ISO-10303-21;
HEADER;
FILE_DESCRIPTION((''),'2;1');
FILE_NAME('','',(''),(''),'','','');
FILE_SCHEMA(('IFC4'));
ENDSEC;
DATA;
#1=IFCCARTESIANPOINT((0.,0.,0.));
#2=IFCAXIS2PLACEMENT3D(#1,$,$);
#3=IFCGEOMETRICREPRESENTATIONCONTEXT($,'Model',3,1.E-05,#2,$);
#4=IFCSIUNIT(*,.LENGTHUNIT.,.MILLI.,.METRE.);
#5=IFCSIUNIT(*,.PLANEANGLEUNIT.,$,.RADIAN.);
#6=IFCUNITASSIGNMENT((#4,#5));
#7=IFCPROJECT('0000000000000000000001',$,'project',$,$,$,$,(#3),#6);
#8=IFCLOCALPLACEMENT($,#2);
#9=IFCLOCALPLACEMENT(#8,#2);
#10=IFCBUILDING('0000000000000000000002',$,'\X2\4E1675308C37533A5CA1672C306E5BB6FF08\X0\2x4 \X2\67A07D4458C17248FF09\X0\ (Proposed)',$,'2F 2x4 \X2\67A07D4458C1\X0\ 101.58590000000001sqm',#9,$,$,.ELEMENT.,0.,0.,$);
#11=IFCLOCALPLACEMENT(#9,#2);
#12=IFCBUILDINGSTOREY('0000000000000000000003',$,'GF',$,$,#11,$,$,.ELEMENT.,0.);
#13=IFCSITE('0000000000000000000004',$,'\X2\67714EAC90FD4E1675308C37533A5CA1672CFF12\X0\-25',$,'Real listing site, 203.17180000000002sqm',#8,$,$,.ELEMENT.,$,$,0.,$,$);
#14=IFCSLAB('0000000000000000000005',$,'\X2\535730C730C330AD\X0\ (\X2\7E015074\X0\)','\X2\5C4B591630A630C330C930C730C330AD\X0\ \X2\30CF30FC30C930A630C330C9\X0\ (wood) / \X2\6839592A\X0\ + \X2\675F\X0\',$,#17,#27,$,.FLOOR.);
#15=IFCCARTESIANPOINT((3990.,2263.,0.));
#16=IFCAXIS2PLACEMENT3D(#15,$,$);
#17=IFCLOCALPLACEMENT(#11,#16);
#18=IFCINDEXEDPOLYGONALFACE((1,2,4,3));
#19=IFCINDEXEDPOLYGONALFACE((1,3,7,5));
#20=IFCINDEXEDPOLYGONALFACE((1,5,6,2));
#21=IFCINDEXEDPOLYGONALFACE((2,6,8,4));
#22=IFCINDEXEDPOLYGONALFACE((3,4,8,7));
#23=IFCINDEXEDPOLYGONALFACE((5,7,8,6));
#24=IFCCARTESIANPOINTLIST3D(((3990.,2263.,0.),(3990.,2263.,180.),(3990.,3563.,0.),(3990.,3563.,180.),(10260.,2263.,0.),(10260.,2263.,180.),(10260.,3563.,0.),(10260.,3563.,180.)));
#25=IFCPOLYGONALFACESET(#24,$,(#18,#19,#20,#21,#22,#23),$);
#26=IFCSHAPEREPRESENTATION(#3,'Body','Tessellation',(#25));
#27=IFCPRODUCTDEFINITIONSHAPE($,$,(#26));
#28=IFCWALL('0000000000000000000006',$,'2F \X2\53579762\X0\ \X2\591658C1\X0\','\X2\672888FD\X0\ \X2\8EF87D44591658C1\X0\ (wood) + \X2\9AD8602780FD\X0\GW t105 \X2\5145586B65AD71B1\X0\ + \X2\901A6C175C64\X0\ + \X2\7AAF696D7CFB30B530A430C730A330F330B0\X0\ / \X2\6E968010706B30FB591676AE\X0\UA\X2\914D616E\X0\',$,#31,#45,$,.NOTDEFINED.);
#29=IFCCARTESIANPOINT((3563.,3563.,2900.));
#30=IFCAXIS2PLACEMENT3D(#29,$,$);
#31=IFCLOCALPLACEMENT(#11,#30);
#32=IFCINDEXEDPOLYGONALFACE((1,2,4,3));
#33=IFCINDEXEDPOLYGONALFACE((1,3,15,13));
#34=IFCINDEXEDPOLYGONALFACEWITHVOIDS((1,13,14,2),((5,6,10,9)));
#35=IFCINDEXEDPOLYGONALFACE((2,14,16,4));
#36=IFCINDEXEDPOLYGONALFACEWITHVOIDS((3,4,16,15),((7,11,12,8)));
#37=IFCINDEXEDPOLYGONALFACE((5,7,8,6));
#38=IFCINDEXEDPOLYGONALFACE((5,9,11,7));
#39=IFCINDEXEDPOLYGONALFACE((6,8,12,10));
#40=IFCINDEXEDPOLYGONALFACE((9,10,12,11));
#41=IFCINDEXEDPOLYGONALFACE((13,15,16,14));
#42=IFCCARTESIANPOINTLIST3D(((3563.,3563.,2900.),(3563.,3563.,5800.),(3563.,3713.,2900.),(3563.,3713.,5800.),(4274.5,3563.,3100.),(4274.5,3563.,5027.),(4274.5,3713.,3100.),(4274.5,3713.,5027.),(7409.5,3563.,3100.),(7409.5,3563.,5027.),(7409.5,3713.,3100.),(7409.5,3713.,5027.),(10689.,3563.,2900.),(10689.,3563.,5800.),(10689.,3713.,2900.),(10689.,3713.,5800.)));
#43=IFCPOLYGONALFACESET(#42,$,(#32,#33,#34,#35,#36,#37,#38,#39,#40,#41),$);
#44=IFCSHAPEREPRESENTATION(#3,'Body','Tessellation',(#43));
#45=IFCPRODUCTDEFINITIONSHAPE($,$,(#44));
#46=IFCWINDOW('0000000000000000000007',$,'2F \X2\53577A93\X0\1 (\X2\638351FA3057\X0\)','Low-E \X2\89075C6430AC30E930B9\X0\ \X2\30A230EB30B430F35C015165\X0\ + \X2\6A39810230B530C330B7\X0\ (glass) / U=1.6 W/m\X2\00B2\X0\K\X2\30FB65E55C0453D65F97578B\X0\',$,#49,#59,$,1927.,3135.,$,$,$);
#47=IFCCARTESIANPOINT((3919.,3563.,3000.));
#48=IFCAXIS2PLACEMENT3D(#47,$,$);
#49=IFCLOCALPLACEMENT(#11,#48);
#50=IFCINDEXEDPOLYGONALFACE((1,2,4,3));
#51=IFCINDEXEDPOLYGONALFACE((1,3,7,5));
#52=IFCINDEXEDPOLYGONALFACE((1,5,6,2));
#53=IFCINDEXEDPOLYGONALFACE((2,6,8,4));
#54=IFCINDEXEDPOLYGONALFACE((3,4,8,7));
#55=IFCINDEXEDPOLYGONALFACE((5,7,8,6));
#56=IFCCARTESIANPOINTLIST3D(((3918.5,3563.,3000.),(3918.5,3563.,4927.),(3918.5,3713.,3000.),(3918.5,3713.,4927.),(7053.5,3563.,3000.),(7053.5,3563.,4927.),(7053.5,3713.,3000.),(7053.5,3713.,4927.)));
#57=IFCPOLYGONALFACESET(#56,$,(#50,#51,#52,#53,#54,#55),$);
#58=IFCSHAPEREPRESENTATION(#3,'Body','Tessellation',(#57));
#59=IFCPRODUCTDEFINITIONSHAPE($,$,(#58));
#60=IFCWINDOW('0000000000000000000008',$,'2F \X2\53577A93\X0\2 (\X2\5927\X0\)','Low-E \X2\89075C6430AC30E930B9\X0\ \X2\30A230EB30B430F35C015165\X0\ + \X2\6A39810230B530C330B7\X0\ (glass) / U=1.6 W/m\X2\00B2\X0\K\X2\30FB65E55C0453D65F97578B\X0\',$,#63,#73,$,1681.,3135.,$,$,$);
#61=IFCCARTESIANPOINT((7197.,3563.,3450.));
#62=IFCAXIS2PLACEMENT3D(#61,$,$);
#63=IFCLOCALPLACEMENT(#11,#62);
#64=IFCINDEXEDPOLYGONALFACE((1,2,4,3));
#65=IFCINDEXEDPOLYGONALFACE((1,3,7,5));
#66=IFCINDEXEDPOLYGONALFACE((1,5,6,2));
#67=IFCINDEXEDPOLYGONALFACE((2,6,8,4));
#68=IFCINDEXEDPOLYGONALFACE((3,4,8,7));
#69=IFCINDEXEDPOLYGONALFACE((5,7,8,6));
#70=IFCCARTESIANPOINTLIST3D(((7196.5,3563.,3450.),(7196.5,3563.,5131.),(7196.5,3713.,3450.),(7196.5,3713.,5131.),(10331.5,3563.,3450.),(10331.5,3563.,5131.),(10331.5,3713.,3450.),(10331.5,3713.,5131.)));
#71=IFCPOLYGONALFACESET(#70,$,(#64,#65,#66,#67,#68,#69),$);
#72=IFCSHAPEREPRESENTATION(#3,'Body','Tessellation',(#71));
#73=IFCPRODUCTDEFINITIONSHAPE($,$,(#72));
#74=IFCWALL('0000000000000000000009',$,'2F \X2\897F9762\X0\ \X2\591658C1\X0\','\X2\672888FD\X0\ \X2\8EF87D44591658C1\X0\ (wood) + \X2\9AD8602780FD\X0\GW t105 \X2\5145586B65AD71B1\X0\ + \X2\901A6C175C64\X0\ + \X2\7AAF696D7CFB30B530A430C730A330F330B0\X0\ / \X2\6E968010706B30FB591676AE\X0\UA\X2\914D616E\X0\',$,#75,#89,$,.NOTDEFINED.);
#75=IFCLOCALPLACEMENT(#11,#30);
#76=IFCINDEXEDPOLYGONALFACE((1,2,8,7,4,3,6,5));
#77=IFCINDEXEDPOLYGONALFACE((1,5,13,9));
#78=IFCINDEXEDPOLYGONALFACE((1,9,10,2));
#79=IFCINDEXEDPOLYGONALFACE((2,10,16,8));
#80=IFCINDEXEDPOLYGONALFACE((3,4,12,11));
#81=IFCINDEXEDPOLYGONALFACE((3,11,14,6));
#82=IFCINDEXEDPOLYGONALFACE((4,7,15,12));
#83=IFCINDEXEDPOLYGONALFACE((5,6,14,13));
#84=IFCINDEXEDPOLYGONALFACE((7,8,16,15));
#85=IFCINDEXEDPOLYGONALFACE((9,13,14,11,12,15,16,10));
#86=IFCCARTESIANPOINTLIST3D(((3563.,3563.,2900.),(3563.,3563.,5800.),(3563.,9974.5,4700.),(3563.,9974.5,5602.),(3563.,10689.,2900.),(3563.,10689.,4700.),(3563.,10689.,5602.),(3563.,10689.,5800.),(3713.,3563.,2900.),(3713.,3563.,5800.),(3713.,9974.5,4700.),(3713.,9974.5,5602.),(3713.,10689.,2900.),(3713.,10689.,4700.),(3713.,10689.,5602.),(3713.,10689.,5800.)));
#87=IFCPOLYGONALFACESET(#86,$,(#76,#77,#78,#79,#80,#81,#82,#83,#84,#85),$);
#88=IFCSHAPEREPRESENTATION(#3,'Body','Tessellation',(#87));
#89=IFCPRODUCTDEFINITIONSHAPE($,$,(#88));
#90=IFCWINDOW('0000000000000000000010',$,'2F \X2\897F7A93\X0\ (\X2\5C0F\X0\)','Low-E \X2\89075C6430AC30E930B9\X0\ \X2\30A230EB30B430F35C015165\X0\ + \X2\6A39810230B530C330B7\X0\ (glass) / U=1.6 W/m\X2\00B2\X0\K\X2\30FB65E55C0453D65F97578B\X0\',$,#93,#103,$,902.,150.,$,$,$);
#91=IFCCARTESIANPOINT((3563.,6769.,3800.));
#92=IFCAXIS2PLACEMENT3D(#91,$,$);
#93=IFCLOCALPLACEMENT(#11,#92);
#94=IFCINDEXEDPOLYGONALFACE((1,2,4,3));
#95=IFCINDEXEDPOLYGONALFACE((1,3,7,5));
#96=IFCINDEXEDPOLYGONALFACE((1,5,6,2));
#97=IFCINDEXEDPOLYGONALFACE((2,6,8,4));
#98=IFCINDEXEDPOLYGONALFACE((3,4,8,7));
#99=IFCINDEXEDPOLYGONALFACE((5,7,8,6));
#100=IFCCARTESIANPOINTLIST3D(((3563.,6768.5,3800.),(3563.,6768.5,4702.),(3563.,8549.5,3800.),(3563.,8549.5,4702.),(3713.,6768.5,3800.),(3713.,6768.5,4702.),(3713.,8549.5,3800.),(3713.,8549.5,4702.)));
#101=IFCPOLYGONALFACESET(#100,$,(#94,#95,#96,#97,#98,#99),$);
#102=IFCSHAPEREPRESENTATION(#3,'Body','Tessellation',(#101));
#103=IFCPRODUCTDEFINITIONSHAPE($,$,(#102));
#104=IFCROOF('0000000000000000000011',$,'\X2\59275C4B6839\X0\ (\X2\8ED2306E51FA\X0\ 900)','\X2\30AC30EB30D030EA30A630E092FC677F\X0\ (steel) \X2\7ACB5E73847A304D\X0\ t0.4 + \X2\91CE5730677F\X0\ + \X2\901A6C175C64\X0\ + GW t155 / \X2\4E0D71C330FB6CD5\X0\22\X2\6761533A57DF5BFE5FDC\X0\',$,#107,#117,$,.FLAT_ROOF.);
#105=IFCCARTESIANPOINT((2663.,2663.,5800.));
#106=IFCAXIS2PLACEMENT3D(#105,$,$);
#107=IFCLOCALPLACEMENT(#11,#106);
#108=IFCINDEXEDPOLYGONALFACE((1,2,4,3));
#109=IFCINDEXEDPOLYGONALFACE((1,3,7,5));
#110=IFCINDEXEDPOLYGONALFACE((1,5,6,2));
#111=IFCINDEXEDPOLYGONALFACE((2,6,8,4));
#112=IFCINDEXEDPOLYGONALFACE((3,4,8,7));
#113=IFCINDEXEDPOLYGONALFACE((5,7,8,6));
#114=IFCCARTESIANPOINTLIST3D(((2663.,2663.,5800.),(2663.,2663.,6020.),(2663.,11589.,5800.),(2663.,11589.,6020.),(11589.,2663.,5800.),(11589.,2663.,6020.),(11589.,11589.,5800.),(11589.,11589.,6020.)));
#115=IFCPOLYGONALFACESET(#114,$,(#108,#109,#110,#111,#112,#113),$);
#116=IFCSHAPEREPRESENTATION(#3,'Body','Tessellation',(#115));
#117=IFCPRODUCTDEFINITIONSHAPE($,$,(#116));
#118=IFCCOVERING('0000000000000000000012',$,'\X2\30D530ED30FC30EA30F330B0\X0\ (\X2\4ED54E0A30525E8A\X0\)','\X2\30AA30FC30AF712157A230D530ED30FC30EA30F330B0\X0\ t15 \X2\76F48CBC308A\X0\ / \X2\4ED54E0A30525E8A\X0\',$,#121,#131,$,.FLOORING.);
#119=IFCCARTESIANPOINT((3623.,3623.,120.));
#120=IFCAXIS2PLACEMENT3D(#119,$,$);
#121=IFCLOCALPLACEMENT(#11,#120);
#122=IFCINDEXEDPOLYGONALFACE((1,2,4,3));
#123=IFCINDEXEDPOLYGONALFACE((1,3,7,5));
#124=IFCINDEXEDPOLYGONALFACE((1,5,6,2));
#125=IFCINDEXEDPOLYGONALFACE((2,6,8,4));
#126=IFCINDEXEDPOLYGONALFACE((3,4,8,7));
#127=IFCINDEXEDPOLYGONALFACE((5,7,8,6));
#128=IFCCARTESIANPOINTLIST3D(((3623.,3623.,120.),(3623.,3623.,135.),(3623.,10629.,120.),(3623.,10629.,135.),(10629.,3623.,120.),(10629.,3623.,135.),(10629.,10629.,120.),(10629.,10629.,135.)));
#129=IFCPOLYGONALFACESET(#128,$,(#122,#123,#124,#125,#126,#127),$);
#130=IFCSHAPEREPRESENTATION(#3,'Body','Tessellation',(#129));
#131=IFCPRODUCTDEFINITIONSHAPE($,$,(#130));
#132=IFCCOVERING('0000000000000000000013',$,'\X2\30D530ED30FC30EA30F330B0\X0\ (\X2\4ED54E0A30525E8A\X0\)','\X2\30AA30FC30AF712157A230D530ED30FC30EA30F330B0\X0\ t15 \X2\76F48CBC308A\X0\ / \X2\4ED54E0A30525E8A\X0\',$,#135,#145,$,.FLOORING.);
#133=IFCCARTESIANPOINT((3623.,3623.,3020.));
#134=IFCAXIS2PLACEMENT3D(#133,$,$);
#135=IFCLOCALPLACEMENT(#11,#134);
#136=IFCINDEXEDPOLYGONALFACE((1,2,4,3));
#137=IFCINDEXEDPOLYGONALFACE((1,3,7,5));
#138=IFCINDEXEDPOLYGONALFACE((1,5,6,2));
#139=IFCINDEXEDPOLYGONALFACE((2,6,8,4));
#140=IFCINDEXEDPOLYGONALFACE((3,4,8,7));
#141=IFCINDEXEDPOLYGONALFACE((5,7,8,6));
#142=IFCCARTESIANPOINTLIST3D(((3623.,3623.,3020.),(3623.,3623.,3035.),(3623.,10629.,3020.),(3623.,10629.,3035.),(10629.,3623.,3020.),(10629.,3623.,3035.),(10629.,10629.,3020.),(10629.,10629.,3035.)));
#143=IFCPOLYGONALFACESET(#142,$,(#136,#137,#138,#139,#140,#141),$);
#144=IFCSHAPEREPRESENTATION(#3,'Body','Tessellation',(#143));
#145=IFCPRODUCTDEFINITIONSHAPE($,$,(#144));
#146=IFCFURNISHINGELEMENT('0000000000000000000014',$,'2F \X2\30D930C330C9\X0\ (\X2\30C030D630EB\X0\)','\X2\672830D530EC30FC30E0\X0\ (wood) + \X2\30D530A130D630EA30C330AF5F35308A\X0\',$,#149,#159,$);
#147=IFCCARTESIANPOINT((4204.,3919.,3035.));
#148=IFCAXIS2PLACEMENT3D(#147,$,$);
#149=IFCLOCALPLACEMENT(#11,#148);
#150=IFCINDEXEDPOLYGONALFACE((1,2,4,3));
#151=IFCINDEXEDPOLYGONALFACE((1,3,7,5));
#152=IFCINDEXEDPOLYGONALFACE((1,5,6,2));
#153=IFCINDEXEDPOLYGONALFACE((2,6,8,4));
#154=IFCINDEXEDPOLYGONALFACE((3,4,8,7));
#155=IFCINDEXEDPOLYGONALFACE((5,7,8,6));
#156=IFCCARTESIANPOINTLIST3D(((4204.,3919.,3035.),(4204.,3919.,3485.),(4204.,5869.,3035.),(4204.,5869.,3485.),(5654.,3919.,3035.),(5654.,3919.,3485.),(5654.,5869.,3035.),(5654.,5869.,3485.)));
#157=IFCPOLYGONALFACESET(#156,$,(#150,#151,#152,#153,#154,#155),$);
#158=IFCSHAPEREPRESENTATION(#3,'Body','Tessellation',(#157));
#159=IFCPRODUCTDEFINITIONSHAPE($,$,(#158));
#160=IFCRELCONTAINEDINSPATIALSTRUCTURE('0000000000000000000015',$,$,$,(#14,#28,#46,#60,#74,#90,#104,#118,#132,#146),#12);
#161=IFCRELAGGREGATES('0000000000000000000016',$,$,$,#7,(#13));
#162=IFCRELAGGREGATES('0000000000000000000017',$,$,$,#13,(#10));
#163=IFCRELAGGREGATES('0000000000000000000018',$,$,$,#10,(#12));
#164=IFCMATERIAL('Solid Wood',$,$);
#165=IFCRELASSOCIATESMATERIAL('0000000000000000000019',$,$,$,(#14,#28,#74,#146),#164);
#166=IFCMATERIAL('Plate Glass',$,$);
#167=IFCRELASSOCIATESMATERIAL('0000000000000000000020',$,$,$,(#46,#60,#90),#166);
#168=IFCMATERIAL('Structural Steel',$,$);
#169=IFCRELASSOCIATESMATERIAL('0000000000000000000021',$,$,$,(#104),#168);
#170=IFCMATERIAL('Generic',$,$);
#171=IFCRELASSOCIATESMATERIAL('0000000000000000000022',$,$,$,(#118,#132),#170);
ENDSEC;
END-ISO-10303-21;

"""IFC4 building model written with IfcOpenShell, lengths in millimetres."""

from ifc_helpers import new_model, si_unit, frame, frame_2d, origin, place, context, project, spatial, rectangle, extrude, material, element, fill, save


model = new_model("IFC4")

# Units and contexts
model_context = context("Model", 3, precision=1e-05, world=origin())
ifc_project = project(units=[si_unit("LENGTHUNIT", "METRE", prefix="MILLI"), si_unit("PLANEANGLEUNIT", "RADIAN")], contexts=[model_context])

# Site, building, storey
site_placement = place(None, origin())
site = spatial("IfcSite", under=ifc_project, at=site_placement, Name="東京都世田谷区岡本２-25", ObjectType="Real listing site, 203.17180000000002sqm", CompositionType="ELEMENT", RefElevation=0.0)
building_placement = place(site_placement, origin())
building = spatial("IfcBuilding", under=site, at=building_placement, Name="世田谷区岡本の家（2x4 枠組壁版） (Proposed)", ObjectType="2F 2x4 枠組壁 101.58590000000001sqm", CompositionType="ELEMENT", ElevationOfRefHeight=0.0, ElevationOfTerrain=0.0)
storey_placement = place(building_placement, origin())
storey = spatial("IfcBuildingStorey", under=building, at=storey_placement, Name="GF", CompositionType="ELEMENT", Elevation=0.0)

# Slab
ifc_material_1 = material(Name="Solid Wood")
slab_1_placement = place(storey_placement, frame((3990.0, 2263.0, 0.0)))
element("IfcSlab", 1, at=slab_1_placement, inside=storey, material=ifc_material_1, Name="南デッキ (縁側)", Description="屋外ウッドデッキ ハードウッド (wood) / 根太 + 束", PredefinedType="FLOOR", context=model_context, shape_type="SweptSolid", body=[
    extrude(rectangle(XDim=6270.0, YDim=1300.0, at=frame_2d((3135.0, 650.0))), frame((3990.0, 2263.0, 0.0)), (0.0, 0.0, 1.0), 180.0),
])

# Shared definitions
ifc_material_2 = material(Name="Plate Glass")

# Wall, openings, windows
wall_1_placement = place(storey_placement, frame((3563.0, 3563.0, 2900.0)))
wall_1 = element("IfcWall", 2, at=wall_1_placement, inside=storey, material=ifc_material_1, Name="2F 南面 外壁", Description="木製 軸組外壁 (wood) + 高性能GW t105 充填断熱 + 通気層 + 窯業系サイディング / 準耐火・外皮UA配慮", PredefinedType="NOTDEFINED", context=model_context, shape_type="SweptSolid", body=[
    extrude(rectangle(XDim=7126.0, YDim=150.0, at=frame_2d((3563.0, 75.0))), frame((3563.0, 3563.0, 2900.0)), (0.0, 0.0, 1.0), 2900.0),
])
opening_1_placement = place(storey_placement, frame((3919.0, 3563.0, 3000.0)))
opening_1 = element("IfcOpeningElement", 3, at=opening_1_placement, cuts=wall_1, PredefinedType="NOTDEFINED", context=model_context, shape_type="SweptSolid", body=[
    extrude(rectangle(XDim=3135.0, YDim=150.0, at=frame_2d((1567.0, 75.0))), frame((3919.0, 3563.0, 3000.0)), (0.0, 0.0, 1.0), 1927.0),
])
opening_2_placement = place(storey_placement, frame((7197.0, 3563.0, 3450.0)))
opening_2 = element("IfcOpeningElement", 4, at=opening_2_placement, cuts=wall_1, PredefinedType="NOTDEFINED", context=model_context, shape_type="SweptSolid", body=[
    extrude(rectangle(XDim=3135.0, YDim=150.0, at=frame_2d((1567.0, 75.0))), frame((7197.0, 3563.0, 3450.0)), (0.0, 0.0, 1.0), 1681.0),
])
window_1_placement = place(storey_placement, frame((3919.0, 3563.0, 3000.0)))
window_1 = element("IfcWindow", 5, at=window_1_placement, inside=storey, material=ifc_material_2, Name="2F 南窓1 (掃出し)", Description="Low-E 複層ガラス アルゴン封入 + 樹脂サッシ (glass) / U=1.6 W/m²K・日射取得型", OverallHeight=1927.0, OverallWidth=3135.0, context=model_context, shape_type="SweptSolid", body=[
    extrude(rectangle(XDim=3135.0, YDim=150.0, at=frame_2d((1567.0, 75.0))), frame((3919.0, 3563.0, 3000.0)), (0.0, 0.0, 1.0), 1927.0),
])
fill(opening_1, window_1)
window_2_placement = place(storey_placement, frame((7197.0, 3563.0, 3450.0)))
window_2 = element("IfcWindow", 6, at=window_2_placement, inside=storey, material=ifc_material_2, Name="2F 南窓2 (大)", Description="Low-E 複層ガラス アルゴン封入 + 樹脂サッシ (glass) / U=1.6 W/m²K・日射取得型", OverallHeight=1681.0, OverallWidth=3135.0, context=model_context, shape_type="SweptSolid", body=[
    extrude(rectangle(XDim=3135.0, YDim=150.0, at=frame_2d((1567.0, 75.0))), frame((7197.0, 3563.0, 3450.0)), (0.0, 0.0, 1.0), 1681.0),
])
fill(opening_2, window_2)

# Wall, opening, window
wall_2_placement = place(storey_placement, frame((3563.0, 3563.0, 2900.0)))
wall_2 = element("IfcWall", 7, at=wall_2_placement, inside=storey, material=ifc_material_1, Name="2F 西面 外壁", Description="木製 軸組外壁 (wood) + 高性能GW t105 充填断熱 + 通気層 + 窯業系サイディング / 準耐火・外皮UA配慮", PredefinedType="NOTDEFINED", context=model_context, shape_type="SweptSolid", body=[
    extrude(rectangle(XDim=150.0, YDim=7126.0, at=frame_2d((75.0, 3563.0))), frame((3563.0, 3563.0, 2900.0)), (0.0, 0.0, 1.0), 2900.0),
])
opening_3_placement = place(storey_placement, frame((3563.0, 6769.0, 3800.0)))
opening_3 = element("IfcOpeningElement", 8, at=opening_3_placement, cuts=wall_2, PredefinedType="NOTDEFINED", context=model_context, shape_type="SweptSolid", body=[
    extrude(rectangle(XDim=150.0, YDim=1781.0, at=frame_2d((75.0, 890.0))), frame((3563.0, 6769.0, 3800.0)), (0.0, 0.0, 1.0), 902.0),
])
window_3_placement = place(storey_placement, frame((3563.0, 6769.0, 3800.0)))
window_3 = element("IfcWindow", 9, at=window_3_placement, inside=storey, material=ifc_material_2, Name="2F 西窓 (小)", Description="Low-E 複層ガラス アルゴン封入 + 樹脂サッシ (glass) / U=1.6 W/m²K・日射取得型", OverallHeight=902.0, OverallWidth=150.0, context=model_context, shape_type="SweptSolid", body=[
    extrude(rectangle(XDim=150.0, YDim=1781.0, at=frame_2d((75.0, 890.0))), frame((3563.0, 6769.0, 3800.0)), (0.0, 0.0, 1.0), 902.0),
])
fill(opening_3, window_3)

# Roof
ifc_material_3 = material(Name="Structural Steel")
roof_placement = place(storey_placement, frame((2663.0, 2663.0, 5800.0)))
element("IfcRoof", 10, at=roof_placement, inside=storey, material=ifc_material_3, Name="大屋根 (軒の出 900)", Description="ガルバリウム鋼板 (steel) 立平葺き t0.4 + 野地板 + 通気層 + GW t155 / 不燃・法22条区域対応", PredefinedType="FLAT_ROOF", context=model_context, shape_type="SweptSolid", body=[
    extrude(rectangle(XDim=8926.0, YDim=8926.0, at=frame_2d((4463.0, 4463.0))), frame((2663.0, 2663.0, 5800.0)), (0.0, 0.0, 1.0), 220.0),
])

# Coverings
ifc_material_4 = material(Name="Generic")
covering_1_placement = place(storey_placement, frame((3623.0, 3623.0, 120.0)))
element("IfcCovering", 11, at=covering_1_placement, inside=storey, material=ifc_material_4, Name="フローリング (仕上げ床)", Description="オーク無垢フローリング t15 直貼り / 仕上げ床", PredefinedType="FLOORING", context=model_context, shape_type="SweptSolid", body=[
    extrude(rectangle(XDim=7006.0, YDim=7006.0, at=frame_2d((3503.0, 3503.0))), frame((3623.0, 3623.0, 120.0)), (0.0, 0.0, 1.0), 15.0),
])
covering_2_placement = place(storey_placement, frame((3623.0, 3623.0, 3020.0)))
element("IfcCovering", 12, at=covering_2_placement, inside=storey, material=ifc_material_4, Name="フローリング (仕上げ床)", Description="オーク無垢フローリング t15 直貼り / 仕上げ床", PredefinedType="FLOORING", context=model_context, shape_type="SweptSolid", body=[
    extrude(rectangle(XDim=7006.0, YDim=7006.0, at=frame_2d((3503.0, 3503.0))), frame((3623.0, 3623.0, 3020.0)), (0.0, 0.0, 1.0), 15.0),
])

# Furnishing element
furnishing_placement = place(storey_placement, frame((4204.0, 3919.0, 3035.0)))
element("IfcFurnishingElement", 13, at=furnishing_placement, inside=storey, material=ifc_material_1, Name="2F ベッド (ダブル)", Description="木フレーム (wood) + ファブリック張り", context=model_context, shape_type="SweptSolid", body=[
    extrude(rectangle(XDim=1450.0, YDim=1950.0, at=frame_2d((725.0, 975.0))), frame((4204.0, 3919.0, 3035.0)), (0.0, 0.0, 1.0), 450.0),
])

save(model, "model.ifc")
